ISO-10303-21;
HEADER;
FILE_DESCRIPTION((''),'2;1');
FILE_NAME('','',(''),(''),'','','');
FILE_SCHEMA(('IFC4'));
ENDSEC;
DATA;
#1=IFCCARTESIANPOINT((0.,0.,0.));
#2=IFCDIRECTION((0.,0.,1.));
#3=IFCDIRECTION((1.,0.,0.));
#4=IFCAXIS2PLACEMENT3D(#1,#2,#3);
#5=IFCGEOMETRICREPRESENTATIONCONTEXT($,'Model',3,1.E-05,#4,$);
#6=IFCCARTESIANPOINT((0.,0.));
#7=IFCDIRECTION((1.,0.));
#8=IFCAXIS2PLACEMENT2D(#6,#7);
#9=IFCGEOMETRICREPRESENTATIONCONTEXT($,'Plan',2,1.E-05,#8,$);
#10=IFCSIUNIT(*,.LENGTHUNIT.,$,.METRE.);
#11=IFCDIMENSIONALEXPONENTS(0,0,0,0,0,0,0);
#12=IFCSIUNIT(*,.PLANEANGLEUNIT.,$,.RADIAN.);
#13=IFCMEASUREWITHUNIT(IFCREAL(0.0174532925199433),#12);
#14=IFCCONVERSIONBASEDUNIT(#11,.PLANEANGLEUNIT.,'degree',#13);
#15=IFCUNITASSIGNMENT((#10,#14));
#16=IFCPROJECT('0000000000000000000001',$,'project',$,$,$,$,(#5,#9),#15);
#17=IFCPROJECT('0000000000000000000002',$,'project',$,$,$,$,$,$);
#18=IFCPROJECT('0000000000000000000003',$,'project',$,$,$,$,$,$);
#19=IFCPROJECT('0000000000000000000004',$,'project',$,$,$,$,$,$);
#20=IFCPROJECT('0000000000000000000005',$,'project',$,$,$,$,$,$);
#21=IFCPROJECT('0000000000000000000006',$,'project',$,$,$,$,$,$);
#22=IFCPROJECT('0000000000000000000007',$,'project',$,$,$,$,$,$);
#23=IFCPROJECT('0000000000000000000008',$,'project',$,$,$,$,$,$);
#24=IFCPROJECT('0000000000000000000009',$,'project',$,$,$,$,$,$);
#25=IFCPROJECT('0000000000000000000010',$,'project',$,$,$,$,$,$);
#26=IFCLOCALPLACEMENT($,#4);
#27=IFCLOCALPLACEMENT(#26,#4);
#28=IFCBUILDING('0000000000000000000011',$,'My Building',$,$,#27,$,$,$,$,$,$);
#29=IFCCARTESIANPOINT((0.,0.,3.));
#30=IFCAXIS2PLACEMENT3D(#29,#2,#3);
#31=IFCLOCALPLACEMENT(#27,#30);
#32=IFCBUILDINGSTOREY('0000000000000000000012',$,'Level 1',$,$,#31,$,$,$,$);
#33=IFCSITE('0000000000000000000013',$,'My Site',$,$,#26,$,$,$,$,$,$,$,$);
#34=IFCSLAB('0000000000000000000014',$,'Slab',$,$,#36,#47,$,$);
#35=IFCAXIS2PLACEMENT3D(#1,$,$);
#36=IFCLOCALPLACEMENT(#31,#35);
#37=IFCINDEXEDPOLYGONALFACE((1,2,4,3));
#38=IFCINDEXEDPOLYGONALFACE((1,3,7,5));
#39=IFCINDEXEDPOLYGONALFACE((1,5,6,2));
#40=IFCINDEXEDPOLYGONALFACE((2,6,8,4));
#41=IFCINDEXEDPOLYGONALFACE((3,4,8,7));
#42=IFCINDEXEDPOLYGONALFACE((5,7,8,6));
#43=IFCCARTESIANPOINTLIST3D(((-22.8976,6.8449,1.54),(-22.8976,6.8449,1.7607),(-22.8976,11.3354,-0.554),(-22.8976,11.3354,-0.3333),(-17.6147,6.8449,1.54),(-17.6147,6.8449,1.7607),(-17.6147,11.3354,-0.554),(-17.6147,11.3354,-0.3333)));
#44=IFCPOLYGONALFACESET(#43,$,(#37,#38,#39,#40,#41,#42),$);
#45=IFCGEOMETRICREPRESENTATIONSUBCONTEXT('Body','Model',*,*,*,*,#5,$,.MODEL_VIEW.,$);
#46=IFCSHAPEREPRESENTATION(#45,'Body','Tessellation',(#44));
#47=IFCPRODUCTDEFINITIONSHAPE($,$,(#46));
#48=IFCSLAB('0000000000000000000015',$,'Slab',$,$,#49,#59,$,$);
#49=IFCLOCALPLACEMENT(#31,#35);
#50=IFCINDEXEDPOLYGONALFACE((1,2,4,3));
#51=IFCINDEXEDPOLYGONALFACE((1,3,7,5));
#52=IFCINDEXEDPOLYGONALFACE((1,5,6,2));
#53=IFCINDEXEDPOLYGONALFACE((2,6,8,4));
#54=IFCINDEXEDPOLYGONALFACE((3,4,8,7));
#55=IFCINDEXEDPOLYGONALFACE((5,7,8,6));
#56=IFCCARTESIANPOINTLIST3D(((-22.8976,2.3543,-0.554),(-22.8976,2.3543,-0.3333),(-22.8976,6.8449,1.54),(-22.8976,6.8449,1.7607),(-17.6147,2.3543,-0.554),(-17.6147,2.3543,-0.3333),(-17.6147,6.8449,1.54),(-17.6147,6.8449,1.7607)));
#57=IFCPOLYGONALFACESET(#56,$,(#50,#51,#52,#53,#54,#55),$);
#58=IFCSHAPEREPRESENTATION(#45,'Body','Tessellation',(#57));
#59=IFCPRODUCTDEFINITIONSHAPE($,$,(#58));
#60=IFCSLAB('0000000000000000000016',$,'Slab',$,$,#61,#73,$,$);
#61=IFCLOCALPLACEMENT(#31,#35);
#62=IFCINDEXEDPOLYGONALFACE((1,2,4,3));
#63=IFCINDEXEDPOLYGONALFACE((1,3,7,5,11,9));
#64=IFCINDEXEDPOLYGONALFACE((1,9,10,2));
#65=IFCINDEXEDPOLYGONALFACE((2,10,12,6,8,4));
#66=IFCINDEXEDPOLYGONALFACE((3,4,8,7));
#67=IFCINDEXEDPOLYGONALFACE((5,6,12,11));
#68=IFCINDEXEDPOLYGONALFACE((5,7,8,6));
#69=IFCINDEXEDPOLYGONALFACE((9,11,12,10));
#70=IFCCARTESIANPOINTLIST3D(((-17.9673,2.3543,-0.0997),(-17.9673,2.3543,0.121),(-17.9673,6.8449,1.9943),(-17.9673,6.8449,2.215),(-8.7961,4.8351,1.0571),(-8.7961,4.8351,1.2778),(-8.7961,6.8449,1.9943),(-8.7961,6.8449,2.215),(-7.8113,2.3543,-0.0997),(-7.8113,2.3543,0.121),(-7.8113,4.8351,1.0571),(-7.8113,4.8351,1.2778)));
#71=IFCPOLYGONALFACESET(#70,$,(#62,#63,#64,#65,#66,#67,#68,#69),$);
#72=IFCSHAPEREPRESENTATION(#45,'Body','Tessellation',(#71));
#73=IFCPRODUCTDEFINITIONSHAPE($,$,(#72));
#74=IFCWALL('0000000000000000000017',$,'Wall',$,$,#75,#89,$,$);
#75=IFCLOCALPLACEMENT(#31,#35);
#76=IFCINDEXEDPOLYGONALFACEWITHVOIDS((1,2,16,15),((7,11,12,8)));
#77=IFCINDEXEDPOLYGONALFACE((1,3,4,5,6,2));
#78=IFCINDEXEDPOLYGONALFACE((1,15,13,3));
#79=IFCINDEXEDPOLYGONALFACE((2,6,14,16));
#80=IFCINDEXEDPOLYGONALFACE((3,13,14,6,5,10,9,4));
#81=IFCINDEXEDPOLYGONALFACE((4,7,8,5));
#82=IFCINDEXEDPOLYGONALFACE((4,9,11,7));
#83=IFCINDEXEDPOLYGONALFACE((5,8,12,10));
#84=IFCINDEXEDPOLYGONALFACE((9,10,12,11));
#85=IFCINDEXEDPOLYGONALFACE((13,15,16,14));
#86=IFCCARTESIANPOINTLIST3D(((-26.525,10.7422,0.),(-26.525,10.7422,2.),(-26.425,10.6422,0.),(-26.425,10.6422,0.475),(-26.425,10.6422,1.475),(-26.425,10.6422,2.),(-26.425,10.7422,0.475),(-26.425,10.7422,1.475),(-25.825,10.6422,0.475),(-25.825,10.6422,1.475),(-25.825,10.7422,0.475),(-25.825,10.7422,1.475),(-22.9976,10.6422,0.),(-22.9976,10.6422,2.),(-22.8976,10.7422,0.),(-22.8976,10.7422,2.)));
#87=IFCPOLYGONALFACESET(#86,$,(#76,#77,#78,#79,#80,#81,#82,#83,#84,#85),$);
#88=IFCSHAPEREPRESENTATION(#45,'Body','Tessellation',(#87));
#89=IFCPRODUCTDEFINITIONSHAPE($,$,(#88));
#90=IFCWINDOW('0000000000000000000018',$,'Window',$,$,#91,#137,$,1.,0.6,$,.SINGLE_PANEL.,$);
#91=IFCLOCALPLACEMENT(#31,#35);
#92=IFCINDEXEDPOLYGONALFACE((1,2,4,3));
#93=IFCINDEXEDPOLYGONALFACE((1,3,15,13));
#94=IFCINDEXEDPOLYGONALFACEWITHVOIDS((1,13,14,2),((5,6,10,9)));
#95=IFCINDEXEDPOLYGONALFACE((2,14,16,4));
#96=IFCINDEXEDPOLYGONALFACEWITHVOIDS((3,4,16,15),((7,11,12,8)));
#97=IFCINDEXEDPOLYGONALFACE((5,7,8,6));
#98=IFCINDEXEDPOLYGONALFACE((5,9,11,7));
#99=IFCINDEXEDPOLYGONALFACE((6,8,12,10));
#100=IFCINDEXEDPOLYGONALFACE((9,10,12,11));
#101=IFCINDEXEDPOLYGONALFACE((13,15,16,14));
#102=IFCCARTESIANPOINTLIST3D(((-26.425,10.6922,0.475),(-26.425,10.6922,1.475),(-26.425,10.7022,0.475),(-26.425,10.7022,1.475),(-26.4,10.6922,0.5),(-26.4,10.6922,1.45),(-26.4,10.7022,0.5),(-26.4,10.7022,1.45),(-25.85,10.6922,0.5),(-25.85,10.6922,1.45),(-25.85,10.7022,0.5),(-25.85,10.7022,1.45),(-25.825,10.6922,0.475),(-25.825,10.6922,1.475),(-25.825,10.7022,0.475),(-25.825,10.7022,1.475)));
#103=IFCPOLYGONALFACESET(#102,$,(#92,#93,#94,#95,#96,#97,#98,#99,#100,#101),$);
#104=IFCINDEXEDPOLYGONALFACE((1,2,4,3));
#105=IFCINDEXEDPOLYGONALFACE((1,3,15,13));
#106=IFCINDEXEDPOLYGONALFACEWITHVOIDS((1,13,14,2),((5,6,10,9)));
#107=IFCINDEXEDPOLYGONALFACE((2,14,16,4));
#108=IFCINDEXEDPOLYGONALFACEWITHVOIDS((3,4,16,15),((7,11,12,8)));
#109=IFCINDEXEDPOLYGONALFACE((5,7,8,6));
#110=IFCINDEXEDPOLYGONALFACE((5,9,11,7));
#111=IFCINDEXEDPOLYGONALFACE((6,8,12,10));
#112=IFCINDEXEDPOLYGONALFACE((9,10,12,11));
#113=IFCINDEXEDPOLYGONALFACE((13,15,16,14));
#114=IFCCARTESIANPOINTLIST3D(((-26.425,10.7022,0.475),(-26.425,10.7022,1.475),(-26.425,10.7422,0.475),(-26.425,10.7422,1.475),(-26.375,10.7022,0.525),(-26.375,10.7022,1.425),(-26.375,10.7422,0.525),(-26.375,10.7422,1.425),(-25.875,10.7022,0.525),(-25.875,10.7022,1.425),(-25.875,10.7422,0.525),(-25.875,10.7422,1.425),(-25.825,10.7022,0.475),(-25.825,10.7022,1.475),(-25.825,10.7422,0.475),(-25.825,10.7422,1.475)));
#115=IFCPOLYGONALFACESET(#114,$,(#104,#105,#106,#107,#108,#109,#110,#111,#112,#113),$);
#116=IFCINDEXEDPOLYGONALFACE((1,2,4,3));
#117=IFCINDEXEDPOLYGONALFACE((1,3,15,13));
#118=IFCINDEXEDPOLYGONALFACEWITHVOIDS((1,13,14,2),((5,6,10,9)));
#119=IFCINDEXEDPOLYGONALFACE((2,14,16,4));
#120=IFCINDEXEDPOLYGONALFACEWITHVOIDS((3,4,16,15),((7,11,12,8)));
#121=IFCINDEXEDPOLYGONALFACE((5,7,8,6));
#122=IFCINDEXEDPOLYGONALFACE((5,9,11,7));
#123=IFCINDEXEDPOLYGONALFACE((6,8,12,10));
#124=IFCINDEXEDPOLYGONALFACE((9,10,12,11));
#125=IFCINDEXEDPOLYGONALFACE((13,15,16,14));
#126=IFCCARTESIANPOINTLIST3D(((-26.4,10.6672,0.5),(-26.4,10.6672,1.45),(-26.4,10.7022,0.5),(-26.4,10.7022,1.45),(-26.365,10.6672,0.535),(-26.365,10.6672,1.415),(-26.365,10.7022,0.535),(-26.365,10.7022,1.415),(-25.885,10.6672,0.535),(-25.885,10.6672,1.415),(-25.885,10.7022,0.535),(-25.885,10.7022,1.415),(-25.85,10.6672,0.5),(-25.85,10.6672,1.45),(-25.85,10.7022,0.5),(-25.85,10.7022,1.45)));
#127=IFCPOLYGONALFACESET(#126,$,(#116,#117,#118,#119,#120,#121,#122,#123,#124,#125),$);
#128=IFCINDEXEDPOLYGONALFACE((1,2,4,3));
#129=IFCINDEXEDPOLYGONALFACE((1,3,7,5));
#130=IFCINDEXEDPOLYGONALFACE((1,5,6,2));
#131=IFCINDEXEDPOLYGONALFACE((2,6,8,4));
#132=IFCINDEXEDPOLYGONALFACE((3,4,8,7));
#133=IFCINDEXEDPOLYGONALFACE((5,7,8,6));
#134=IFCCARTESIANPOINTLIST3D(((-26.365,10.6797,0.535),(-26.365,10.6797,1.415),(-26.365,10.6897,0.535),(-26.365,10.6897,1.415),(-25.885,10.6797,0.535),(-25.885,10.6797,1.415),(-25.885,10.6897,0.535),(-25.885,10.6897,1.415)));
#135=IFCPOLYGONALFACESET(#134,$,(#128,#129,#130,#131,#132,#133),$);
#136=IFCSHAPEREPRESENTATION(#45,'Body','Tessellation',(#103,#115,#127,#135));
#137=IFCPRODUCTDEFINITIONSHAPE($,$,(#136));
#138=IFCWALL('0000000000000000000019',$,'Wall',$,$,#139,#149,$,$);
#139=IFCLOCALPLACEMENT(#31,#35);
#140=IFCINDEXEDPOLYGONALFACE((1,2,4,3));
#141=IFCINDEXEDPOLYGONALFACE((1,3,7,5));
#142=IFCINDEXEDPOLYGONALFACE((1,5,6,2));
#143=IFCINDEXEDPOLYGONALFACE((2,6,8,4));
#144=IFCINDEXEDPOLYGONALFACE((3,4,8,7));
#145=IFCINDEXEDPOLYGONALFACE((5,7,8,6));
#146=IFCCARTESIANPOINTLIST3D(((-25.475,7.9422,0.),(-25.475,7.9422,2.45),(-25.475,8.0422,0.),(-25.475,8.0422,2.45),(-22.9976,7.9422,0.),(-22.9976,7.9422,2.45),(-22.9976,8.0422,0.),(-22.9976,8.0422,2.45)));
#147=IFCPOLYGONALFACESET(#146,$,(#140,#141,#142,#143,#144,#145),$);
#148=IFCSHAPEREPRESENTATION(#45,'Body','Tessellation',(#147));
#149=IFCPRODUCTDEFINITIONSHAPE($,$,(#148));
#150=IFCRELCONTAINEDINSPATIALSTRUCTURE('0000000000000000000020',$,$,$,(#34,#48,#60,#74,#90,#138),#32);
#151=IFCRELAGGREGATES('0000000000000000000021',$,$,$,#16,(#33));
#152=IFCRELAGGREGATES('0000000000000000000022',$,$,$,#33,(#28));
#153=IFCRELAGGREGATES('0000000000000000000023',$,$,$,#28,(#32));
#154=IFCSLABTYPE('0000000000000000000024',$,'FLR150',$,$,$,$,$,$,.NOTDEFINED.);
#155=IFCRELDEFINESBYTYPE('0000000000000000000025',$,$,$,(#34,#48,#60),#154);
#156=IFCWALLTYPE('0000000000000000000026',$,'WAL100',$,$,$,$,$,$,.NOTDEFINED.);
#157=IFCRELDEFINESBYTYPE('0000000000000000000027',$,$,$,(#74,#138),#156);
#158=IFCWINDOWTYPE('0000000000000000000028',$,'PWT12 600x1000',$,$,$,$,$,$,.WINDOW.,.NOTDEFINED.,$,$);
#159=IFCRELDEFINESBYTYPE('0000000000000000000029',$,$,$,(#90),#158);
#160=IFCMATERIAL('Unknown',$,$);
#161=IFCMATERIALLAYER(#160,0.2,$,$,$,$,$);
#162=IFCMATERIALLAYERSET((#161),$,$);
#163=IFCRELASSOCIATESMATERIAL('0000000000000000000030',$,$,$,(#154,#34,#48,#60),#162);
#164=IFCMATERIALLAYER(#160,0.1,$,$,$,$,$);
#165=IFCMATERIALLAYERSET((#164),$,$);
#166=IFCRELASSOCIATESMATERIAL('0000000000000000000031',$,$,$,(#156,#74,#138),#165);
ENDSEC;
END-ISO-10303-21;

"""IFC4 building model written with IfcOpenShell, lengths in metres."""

from ifc_helpers import new_model, entity, si_unit, converted_unit, frame, origin_with_axes, origin_2d_with_axis, place, context, subcontext, project, spatial, line, indexed_curve, outline, extrude, clip, halfspace, shape, source, transform, mapped, material, layer, layer_set, layer_usage, type_object, type_shapes, element, fill, save


model = new_model("IFC4")

# Units and contexts
model_context = context("Model", 3, precision=1e-05, world=origin_with_axes())
plan_context = context("Plan", 2, precision=1e-05, world=origin_2d_with_axis())
body_context_1 = subcontext(model_context, "Body", "Model", "MODEL_VIEW")
body_context_2 = subcontext(plan_context, "Body", "Plan", "PLAN_VIEW")
ifc_project_1 = project(units=[si_unit("LENGTHUNIT", "METRE"), converted_unit("PLANEANGLEUNIT", "degree", entity("IfcReal", 0.0174532925199433), si_unit("PLANEANGLEUNIT", "RADIAN"), dimensions=[0, 0, 0, 0, 0, 0, 0])], contexts=[model_context, plan_context])
ifc_project_2 = project()
ifc_project_3 = project()
ifc_project_4 = project()
ifc_project_5 = project()
ifc_project_6 = project()
ifc_project_7 = project()
ifc_project_8 = project()
ifc_project_9 = project()
ifc_project_10 = project()

# Site, building, storey
site_placement = place(None, origin_with_axes())
site = spatial("IfcSite", under=ifc_project_1, at=site_placement, Name="My Site")
building_placement = place(site_placement, origin_with_axes())
building = spatial("IfcBuilding", under=site, at=building_placement, Name="My Building")
storey_placement = place(building_placement, frame((0.0, 0.0, 3.0), z_axis=(0.0, 0.0, 1.0), x_axis=(1.0, 0.0, 0.0)))
storey = spatial("IfcBuildingStorey", under=building, at=storey_placement, Name="Level 1")

# Slabs
ifc_material = material(Name="Unknown")
ifc_layer_1 = layer(ifc_material, 0.2)
ifc_layer_set_1 = layer_set([ifc_layer_1])
slab_type_1 = type_object("IfcSlabType", Name="FLR150", PredefinedType="NOTDEFINED", material=ifc_layer_set_1)
ifc_layer_usage_1 = layer_usage(ifc_layer_set_1, "AXIS3", "POSITIVE", 0.0)
slab_1_placement = place(storey_placement, frame((-22.8976, 6.8449, 1.54), z_axis=(0.0, 0.422618, 0.906308), x_axis=(1.0, 0.0, 0.0)))
element("IfcSlab", 1, at=slab_1_placement, inside=storey, type_object=slab_type_1, material=ifc_layer_usage_1, Name="Slab", context=body_context_1, shape_type="SweptSolid", body=[
    extrude(outline(indexed_curve([(5.2829, 4.9547), (5.2829, 0.0), (0.0, 0.0), (0.0, 4.9547)], segments=[line(3, 2), line(2, 1), line(1, 4), line(4, 3)], self_intersect=False)), None, (0.0, -0.422618, 0.906308), 0.2207),
])
ifc_layer_usage_2 = layer_usage(ifc_layer_set_1, "AXIS3", "POSITIVE", 0.0)
slab_2_placement = place(storey_placement, frame((-17.6147, 6.8449, 1.54), z_axis=(0.0, -0.422618, 0.906308), x_axis=(-1.0, 0.0, 0.0)))
element("IfcSlab", 2, at=slab_2_placement, inside=storey, type_object=slab_type_1, material=ifc_layer_usage_2, Name="Slab", context=body_context_1, shape_type="SweptSolid", body=[
    extrude(outline(indexed_curve([(0.0, 0.0), (5.2829, 0.0), (5.2829, 4.9547), (0.0, 4.9547)], segments=[line(3, 2), line(2, 1), line(1, 4), line(4, 3)], self_intersect=False)), None, (0.0, -0.422618, 0.906308), 0.2207),
])
ifc_layer_usage_3 = layer_usage(ifc_layer_set_1, "AXIS3", "POSITIVE", 0.0)
slab_3_placement = place(storey_placement, frame((-8.7961, 6.8449, 1.9943), z_axis=(0.0, -0.422618, 0.906308), x_axis=(-1.0, 0.0, 0.0)))
element("IfcSlab", 3, at=slab_3_placement, inside=storey, type_object=slab_type_1, material=ifc_layer_usage_3, Name="Slab", context=body_context_1, shape_type="SweptSolid", body=[
    extrude(outline(indexed_curve([(-0.9849, 4.9547), (-0.9849, 2.2176), (0.0, 2.2176), (0.0, 0.0), (9.1712, 0.0), (9.1712, 4.9547)], segments=[line(6, 5), line(5, 4), line(4, 3), line(3, 2), line(2, 1), line(1, 6)], self_intersect=False)), None, (0.0, -0.422618, 0.906308), 0.2207),
])

# Wall, opening, window
ifc_layer_2 = layer(ifc_material, 0.1)
ifc_layer_set_2 = layer_set([ifc_layer_2])
ifc_layer_usage_4 = layer_usage(ifc_layer_set_2, "AXIS2", "POSITIVE", 0.0)
wall_type = type_object("IfcWallType", Name="WAL100", PredefinedType="NOTDEFINED", material=ifc_layer_set_2)
wall_1_placement = place(storey_placement, frame((-22.8976, 10.7422, 0.0), z_axis=(0.0, 0.0, 1.0), x_axis=(-1.0, 0.000001, 0.0)))
wall_1 = element("IfcWall", 4, at=wall_1_placement, inside=storey, type_object=wall_type, material=ifc_layer_usage_4, Name="Wall", context=body_context_1, shape_type="Clipping", body=[
    clip(clip(extrude(outline(indexed_curve([(0.0, 0.0), (0.0, 0.1), (3.6274, 0.1), (3.6274, 0.0), (0.0, 0.0)], self_intersect=False)), origin_with_axes(), (0.0, 0.0, 1.0), 2.0), halfspace(frame((0.0, 0.0, -3.0), z_axis=(-0.200001, 0.200001, 0.0), x_axis=(0.1, 0.1, 0.0)), False)), halfspace(frame((3.6274, 0.0, -3.0), z_axis=(0.200001, 0.200001, 0.0), x_axis=(-0.1, 0.1, 0.0)), False)),
])
shared_shape_1 = source(origin_with_axes(), body_context_1, "Body", "SweptSolid", [
    extrude(outline(indexed_curve([(0.0, 0.0), (0.6, 0.0), (0.6, 1.0), (0.0, 1.0)], segments=[line(1, 2, 2, 3, 3, 4, 4, 1)])), frame((0.0, -0.1, 0.0), z_axis=(0.0, -1.0, 0.0), x_axis=(1.0, 0.0, 0.0)), (0.0, 0.0, -1.0), 0.3),
])
opening_1_placement = place(wall_1_placement, frame((2.9274, 0.0, 0.475), z_axis=(0.0, 0.0, 1.0), x_axis=(1.0, 0.0, 0.0)))
opening_1 = element("IfcOpeningElement", 5, at=opening_1_placement, cuts=wall_1, PredefinedType="OPENING", context=body_context_1, shape_type="MappedRepresentation", body=[
    mapped(shared_shape_1, transform((0.0, 0.0, 0.0), x_axis=(1.0, 0.0, 0.0), y_axis=(0.0, 1.0, 0.0), z_axis=(0.0, 0.0, 1.0), scale=1.0)),
])
window_type_1 = type_object("IfcWindowType", Name="PWT12 600x1000", PartitioningType="NOTDEFINED", PredefinedType="WINDOW")
shared_shape_2 = source(origin_with_axes(), body_context_1, "Body", "SweptSolid", [
    extrude(outline(indexed_curve([(0.0, 0.0), (0.6, 0.0), (0.6, 1.0), (0.0, 1.0)], segments=[line(1, 2, 2, 3, 3, 4, 4, 1)]), holes=[indexed_curve([(0.025, 0.025), (0.575, 0.025), (0.575, 0.975), (0.025, 0.975)], segments=[line(1, 2, 2, 3, 3, 4, 4, 1)])]), frame((0.0, 0.04, 0.0), z_axis=(0.0, -1.0, 0.0), x_axis=(1.0, 0.0, 0.0)), (0.0, 0.0, -1.0), 0.01),
    extrude(outline(indexed_curve([(0.0, 0.0), (0.6, 0.0), (0.6, 1.0), (0.0, 1.0)], segments=[line(1, 2, 2, 3, 3, 4, 4, 1)]), holes=[indexed_curve([(0.05, 0.05), (0.55, 0.05), (0.55, 0.95), (0.05, 0.95)], segments=[line(1, 2, 2, 3, 3, 4, 4, 1)])]), frame((0.0, 0.0, 0.0), z_axis=(0.0, -1.0, 0.0), x_axis=(1.0, 0.0, 0.0)), (0.0, 0.0, -1.0), 0.04),
    extrude(outline(indexed_curve([(0.0, 0.0), (0.55, 0.0), (0.55, 0.95), (0.0, 0.95)], segments=[line(1, 2, 2, 3, 3, 4, 4, 1)]), holes=[indexed_curve([(0.035, 0.035), (0.515, 0.035), (0.515, 0.915), (0.035, 0.915)], segments=[line(1, 2, 2, 3, 3, 4, 4, 1)])]), frame((0.025, 0.04, 0.025), z_axis=(0.0, -1.0, 0.0), x_axis=(1.0, 0.0, 0.0)), (0.0, 0.0, -1.0), 0.035),
    extrude(outline(indexed_curve([(0.035, 0.035), (0.515, 0.035), (0.515, 0.915), (0.035, 0.915)], segments=[line(1, 2, 2, 3, 3, 4, 4, 1)])), frame((0.025, 0.0525, 0.025), z_axis=(0.0, -1.0, 0.0), x_axis=(1.0, 0.0, 0.0)), (0.0, 0.0, -1.0), 0.01),
])
shared_shape_3 = source(origin_with_axes(), body_context_2, "Body", "Curve2D", [
    entity("IfcIndexedPolyCurve", entity("IfcCartesianPointList2D", [[0.05, 0.0], [0.55, 0.0]]), [entity("IfcLineIndex", [1, 2])]),
    entity("IfcIndexedPolyCurve", entity("IfcCartesianPointList2D", [[0.0, 0.05], [0.025, 0.05], [0.025, 0.04], [0.05, 0.04], [0.05, 0.0], [0.0, 0.0]]), [entity("IfcLineIndex", [1, 2, 2, 3, 3, 4, 4, 5, 5, 6, 6, 1])]),
    entity("IfcIndexedPolyCurve", entity("IfcCartesianPointList2D", [[0.6, 0.05], [0.575, 0.05], [0.575, 0.04], [0.55, 0.04], [0.55, 0.0], [0.6, 0.0]]), [entity("IfcLineIndex", [1, 2, 2, 3, 3, 4, 4, 5, 5, 6, 6, 1])]),
    entity("IfcIndexedPolyCurve", entity("IfcCartesianPointList2D", [[0.025, 0.04], [0.06, 0.04], [0.06, 0.075], [0.025, 0.075]]), [entity("IfcLineIndex", [1, 2, 2, 3, 3, 4, 4, 1])]),
    entity("IfcIndexedPolyCurve", entity("IfcCartesianPointList2D", [[0.575, 0.04], [0.54, 0.04], [0.54, 0.075], [0.575, 0.075]]), [entity("IfcLineIndex", [1, 2, 2, 3, 3, 4, 4, 1])]),
    entity("IfcIndexedPolyCurve", entity("IfcCartesianPointList2D", [[0.06, 0.04], [0.54, 0.04]]), [entity("IfcLineIndex", [1, 2])]),
    entity("IfcIndexedPolyCurve", entity("IfcCartesianPointList2D", [[0.06, 0.075], [0.54, 0.075]]), [entity("IfcLineIndex", [1, 2])]),
    entity("IfcIndexedPolyCurve", entity("IfcCartesianPointList2D", [[0.06, 0.0575], [0.54, 0.0575]]), [entity("IfcLineIndex", [1, 2])]),
])
type_shapes(window_type_1, [shared_shape_2, shared_shape_3])
window_1_placement = place(opening_1_placement, frame((0.0, 0.0, 0.0), z_axis=(0.0, 0.0, 1.0), x_axis=(1.0, 0.0, 0.0)))
window_1 = element("IfcWindow", 6, at=window_1_placement, inside=storey, type_object=window_type_1, Name="Window", OverallHeight=1.0, OverallWidth=0.6, PartitioningType="SINGLE_PANEL", shapes=[
    shape(body_context_1, "Body", "MappedRepresentation", [mapped(shared_shape_2, transform((0.0, 0.0, 0.0), x_axis=(1.0, 0.0, 0.0), y_axis=(0.0, 1.0, 0.0), z_axis=(0.0, 0.0, 1.0), scale=1.0))]),
    shape(body_context_2, "Body", "MappedRepresentation", [mapped(shared_shape_3, transform((0.0, 0.0, 0.0), x_axis=(1.0, 0.0, 0.0), y_axis=(0.0, 1.0, 0.0), z_axis=(0.0, 0.0, 1.0), scale=1.0))]),
])
fill(opening_1, window_1)

# Wall
ifc_layer_usage_5 = layer_usage(ifc_layer_set_2, "AXIS2", "POSITIVE", 0.0)
wall_2_placement = place(storey_placement, frame((-22.9976, 8.0422, 0.0), z_axis=(0.0, 0.0, 1.0), x_axis=(-1.0, 0.0, 0.0)))
element("IfcWall", 7, at=wall_2_placement, inside=storey, type_object=wall_type, material=ifc_layer_usage_5, Name="Wall", context=body_context_1, shape_type="SweptSolid", body=[
    extrude(outline(indexed_curve([(0.0, 0.0), (0.0, 0.1), (2.4774, 0.1), (2.4774, 0.0), (0.0, 0.0)], self_intersect=False)), origin_with_axes(), (0.0, 0.0, 1.0), 2.45),
])

save(model, "model.ifc")
